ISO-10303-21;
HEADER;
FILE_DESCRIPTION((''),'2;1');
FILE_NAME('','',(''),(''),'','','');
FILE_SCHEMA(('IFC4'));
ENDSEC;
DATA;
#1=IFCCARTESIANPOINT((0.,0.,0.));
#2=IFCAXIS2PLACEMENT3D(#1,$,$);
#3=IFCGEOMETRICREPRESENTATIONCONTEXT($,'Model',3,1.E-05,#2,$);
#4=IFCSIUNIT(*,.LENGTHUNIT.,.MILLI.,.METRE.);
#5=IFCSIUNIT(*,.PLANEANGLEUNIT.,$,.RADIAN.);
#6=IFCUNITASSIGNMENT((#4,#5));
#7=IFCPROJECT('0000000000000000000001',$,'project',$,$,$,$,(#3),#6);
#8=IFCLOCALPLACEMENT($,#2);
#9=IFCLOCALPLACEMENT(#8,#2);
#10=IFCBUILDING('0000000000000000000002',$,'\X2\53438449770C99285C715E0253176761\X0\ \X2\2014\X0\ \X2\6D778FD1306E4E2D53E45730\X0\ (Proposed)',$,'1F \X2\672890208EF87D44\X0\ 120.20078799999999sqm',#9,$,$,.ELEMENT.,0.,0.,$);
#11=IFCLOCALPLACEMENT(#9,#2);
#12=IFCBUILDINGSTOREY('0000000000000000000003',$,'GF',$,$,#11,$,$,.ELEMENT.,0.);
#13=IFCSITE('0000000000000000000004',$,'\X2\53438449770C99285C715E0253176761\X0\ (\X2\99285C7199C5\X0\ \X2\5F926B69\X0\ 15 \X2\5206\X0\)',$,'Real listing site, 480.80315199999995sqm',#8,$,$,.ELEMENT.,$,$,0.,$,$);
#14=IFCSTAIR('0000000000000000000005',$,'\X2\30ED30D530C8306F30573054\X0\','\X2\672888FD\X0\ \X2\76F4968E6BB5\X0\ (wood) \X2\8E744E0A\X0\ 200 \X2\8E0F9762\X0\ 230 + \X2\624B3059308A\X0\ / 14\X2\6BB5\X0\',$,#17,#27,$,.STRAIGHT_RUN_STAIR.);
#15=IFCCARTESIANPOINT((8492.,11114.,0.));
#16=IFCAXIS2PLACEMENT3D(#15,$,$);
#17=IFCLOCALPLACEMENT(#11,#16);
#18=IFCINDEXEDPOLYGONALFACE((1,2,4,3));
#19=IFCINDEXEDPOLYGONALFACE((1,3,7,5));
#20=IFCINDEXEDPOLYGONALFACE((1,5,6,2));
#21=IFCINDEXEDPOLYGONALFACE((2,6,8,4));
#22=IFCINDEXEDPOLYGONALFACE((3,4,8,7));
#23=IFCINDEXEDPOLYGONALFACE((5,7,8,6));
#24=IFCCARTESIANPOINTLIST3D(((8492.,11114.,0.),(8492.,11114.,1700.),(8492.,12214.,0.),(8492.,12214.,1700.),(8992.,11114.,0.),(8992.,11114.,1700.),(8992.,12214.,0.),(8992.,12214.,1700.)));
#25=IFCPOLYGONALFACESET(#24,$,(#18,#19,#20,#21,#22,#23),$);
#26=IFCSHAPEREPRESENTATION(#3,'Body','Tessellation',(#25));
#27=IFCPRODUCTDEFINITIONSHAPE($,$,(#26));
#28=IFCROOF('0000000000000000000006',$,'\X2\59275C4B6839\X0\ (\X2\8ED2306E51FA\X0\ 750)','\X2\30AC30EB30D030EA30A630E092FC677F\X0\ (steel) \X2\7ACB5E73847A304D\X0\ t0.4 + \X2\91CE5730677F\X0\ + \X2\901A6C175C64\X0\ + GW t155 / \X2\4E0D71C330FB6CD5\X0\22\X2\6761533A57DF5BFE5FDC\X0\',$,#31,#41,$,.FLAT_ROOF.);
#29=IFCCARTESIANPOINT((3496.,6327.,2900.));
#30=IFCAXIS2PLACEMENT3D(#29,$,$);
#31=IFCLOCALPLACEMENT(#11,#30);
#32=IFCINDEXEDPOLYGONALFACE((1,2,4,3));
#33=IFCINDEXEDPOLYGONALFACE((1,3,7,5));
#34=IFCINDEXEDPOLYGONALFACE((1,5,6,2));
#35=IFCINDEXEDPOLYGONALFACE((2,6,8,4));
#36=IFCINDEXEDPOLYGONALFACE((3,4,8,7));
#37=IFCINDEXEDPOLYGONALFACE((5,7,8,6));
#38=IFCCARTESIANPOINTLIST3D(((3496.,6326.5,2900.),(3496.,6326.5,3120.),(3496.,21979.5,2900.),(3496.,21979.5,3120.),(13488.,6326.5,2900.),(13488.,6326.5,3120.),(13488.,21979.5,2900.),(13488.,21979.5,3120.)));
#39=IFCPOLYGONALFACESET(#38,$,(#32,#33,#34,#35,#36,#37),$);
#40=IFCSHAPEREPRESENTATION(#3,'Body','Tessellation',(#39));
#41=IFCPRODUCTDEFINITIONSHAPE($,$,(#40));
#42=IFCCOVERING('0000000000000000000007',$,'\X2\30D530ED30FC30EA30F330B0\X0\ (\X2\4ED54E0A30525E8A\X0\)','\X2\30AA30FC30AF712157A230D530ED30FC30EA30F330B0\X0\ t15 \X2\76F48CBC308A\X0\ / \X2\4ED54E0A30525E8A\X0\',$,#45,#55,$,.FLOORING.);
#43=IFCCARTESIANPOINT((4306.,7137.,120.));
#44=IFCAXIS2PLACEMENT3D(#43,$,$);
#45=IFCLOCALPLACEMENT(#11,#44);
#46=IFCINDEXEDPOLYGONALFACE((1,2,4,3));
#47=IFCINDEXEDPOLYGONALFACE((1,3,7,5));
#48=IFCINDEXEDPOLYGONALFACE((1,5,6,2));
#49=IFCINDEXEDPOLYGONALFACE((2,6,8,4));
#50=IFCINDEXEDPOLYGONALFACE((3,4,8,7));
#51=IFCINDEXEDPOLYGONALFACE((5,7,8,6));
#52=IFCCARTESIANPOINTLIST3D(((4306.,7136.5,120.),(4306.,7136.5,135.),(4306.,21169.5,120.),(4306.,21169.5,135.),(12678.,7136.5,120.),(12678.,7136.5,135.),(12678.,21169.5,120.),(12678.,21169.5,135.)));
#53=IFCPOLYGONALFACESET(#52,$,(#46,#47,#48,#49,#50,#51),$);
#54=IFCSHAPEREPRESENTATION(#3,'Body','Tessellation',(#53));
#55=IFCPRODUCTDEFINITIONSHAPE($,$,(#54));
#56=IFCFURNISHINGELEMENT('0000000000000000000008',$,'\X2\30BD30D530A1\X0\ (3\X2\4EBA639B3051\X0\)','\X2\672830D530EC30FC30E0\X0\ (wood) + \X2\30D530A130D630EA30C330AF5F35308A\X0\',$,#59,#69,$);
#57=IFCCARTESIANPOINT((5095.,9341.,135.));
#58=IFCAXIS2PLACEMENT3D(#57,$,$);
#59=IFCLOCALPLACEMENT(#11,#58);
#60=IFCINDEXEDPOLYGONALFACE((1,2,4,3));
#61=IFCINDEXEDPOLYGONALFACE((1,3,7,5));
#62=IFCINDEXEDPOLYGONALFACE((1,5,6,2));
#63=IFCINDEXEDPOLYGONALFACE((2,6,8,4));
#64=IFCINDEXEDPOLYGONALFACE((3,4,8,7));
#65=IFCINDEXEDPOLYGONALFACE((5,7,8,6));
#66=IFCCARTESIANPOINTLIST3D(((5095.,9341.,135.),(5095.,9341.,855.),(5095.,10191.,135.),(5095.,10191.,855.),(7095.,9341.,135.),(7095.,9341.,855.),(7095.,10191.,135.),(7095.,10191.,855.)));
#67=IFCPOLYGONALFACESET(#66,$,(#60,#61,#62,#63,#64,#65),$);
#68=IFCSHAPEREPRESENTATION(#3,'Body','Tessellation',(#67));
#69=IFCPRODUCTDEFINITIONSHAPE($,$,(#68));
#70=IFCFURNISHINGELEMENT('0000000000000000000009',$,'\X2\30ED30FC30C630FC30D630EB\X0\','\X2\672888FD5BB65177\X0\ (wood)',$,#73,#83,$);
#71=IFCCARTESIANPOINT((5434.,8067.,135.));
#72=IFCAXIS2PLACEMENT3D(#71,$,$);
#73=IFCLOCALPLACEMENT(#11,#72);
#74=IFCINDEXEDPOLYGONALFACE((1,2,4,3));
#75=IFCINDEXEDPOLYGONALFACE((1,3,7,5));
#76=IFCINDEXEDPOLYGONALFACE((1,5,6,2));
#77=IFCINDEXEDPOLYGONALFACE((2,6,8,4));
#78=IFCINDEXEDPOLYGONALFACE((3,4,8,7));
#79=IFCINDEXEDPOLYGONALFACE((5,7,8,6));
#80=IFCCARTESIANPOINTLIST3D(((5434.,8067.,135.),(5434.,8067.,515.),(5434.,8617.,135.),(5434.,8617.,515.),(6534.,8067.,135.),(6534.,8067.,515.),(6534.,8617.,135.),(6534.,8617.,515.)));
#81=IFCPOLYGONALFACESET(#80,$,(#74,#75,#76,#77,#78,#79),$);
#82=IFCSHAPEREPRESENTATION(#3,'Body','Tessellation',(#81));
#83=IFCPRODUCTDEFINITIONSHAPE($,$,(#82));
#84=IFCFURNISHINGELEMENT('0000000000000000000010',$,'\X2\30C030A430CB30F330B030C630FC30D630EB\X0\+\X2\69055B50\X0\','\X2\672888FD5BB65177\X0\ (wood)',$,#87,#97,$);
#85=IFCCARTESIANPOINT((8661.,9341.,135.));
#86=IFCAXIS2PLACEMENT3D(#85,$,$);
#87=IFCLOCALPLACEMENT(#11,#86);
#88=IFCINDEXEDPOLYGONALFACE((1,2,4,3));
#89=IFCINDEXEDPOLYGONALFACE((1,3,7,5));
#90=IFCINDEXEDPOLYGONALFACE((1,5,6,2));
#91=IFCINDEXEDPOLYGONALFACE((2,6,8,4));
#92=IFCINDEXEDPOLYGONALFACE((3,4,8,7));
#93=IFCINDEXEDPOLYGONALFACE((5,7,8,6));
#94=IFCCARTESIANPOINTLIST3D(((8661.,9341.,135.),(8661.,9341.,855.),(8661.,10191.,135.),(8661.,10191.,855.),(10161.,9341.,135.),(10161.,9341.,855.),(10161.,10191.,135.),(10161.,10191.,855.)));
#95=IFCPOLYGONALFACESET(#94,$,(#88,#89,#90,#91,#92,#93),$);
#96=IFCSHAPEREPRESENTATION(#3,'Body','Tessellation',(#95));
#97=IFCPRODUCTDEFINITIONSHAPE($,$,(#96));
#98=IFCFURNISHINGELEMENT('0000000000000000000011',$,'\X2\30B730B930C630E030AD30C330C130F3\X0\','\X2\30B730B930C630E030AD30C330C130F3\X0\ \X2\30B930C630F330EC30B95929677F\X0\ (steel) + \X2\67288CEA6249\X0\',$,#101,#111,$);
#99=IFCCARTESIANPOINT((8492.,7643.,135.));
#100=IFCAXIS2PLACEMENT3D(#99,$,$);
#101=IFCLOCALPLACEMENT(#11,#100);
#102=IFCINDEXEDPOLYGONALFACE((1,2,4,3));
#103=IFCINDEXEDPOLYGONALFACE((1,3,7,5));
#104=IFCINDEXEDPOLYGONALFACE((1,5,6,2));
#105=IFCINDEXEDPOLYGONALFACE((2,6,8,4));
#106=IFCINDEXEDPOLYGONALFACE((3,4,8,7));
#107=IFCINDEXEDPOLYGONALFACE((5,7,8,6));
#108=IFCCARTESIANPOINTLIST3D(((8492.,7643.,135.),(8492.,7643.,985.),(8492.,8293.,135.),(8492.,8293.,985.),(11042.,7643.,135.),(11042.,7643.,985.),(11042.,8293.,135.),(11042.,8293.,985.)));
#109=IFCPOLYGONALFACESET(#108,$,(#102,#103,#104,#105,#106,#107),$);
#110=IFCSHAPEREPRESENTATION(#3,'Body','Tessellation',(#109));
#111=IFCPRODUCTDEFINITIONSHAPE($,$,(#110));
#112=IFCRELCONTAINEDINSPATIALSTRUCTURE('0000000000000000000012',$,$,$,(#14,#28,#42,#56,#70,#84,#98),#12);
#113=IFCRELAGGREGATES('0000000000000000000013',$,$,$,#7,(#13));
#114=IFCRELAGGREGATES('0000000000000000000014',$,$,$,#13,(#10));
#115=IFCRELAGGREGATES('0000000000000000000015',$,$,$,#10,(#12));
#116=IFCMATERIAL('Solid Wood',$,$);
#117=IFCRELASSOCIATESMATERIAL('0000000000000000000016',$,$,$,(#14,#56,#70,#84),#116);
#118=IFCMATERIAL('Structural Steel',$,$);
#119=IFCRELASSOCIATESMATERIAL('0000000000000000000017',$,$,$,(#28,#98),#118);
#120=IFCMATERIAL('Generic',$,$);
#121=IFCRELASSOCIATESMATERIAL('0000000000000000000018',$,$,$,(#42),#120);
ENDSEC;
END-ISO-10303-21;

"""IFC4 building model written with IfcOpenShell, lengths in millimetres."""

from ifc_helpers import new_model, si_unit, frame, frame_2d, origin, place, context, project, spatial, rectangle, extrude, material, element, save


model = new_model("IFC4")

# Units and contexts
model_context = context("Model", 3, precision=1e-05, world=origin())
ifc_project = project(units=[si_unit("LENGTHUNIT", "METRE", prefix="MILLI"), si_unit("PLANEANGLEUNIT", "RADIAN")], contexts=[model_context])

# Site, building, storey
site_placement = place(None, origin())
site = spatial("IfcSite", under=ifc_project, at=site_placement, Name="千葉県館山市北条 (館山駅 徒歩 15 分)", ObjectType="Real listing site, 480.80315199999995sqm", CompositionType="ELEMENT", RefElevation=0.0)
building_placement = place(site_placement, origin())
building = spatial("IfcBuilding", under=site, at=building_placement, Name="千葉県館山市北条 — 海近の中古地 (Proposed)", ObjectType="1F 木造軸組 120.20078799999999sqm", CompositionType="ELEMENT", ElevationOfRefHeight=0.0, ElevationOfTerrain=0.0)
storey_placement = place(building_placement, origin())
storey = spatial("IfcBuildingStorey", under=building, at=storey_placement, Name="GF", CompositionType="ELEMENT", Elevation=0.0)

# Shared definitions
ifc_material_1 = material(Name="Solid Wood")

# Stair
stair_placement = place(storey_placement, frame((8492.0, 11114.0, 0.0)))
element("IfcStair", 1, at=stair_placement, inside=storey, material=ifc_material_1, Name="ロフトはしご", Description="木製 直階段 (wood) 蹴上 200 踏面 230 + 手すり / 14段", PredefinedType="STRAIGHT_RUN_STAIR", context=model_context, shape_type="SweptSolid", body=[
    extrude(rectangle(XDim=500.0, YDim=1100.0, at=frame_2d((250.0, 550.0))), frame((8492.0, 11114.0, 0.0)), (0.0, 0.0, 1.0), 1700.0),
])

# Roof
ifc_material_2 = material(Name="Structural Steel")
roof_placement = place(storey_placement, frame((3496.0, 6327.0, 2900.0)))
element("IfcRoof", 2, at=roof_placement, inside=storey, material=ifc_material_2, Name="大屋根 (軒の出 750)", Description="ガルバリウム鋼板 (steel) 立平葺き t0.4 + 野地板 + 通気層 + GW t155 / 不燃・法22条区域対応", PredefinedType="FLAT_ROOF", context=model_context, shape_type="SweptSolid", body=[
    extrude(rectangle(XDim=9992.0, YDim=15653.0, at=frame_2d((4996.0, 7826.0))), frame((3496.0, 6327.0, 2900.0)), (0.0, 0.0, 1.0), 220.0),
])

# Covering
ifc_material_3 = material(Name="Generic")
covering_placement = place(storey_placement, frame((4306.0, 7137.0, 120.0)))
element("IfcCovering", 3, at=covering_placement, inside=storey, material=ifc_material_3, Name="フローリング (仕上げ床)", Description="オーク無垢フローリング t15 直貼り / 仕上げ床", PredefinedType="FLOORING", context=model_context, shape_type="SweptSolid", body=[
    extrude(rectangle(XDim=8372.0, YDim=14033.0, at=frame_2d((4186.0, 7016.0))), frame((4306.0, 7137.0, 120.0)), (0.0, 0.0, 1.0), 15.0),
])

# Furnishing elements
furnishing_1_placement = place(storey_placement, frame((5095.0, 9341.0, 135.0)))
element("IfcFurnishingElement", 4, at=furnishing_1_placement, inside=storey, material=ifc_material_1, Name="ソファ (3人掛け)", Description="木フレーム (wood) + ファブリック張り", context=model_context, shape_type="SweptSolid", body=[
    extrude(rectangle(XDim=2000.0, YDim=850.0, at=frame_2d((1000.0, 425.0))), frame((5095.0, 9341.0, 135.0)), (0.0, 0.0, 1.0), 720.0),
])
furnishing_2_placement = place(storey_placement, frame((5434.0, 8067.0, 135.0)))
element("IfcFurnishingElement", 5, at=furnishing_2_placement, inside=storey, material=ifc_material_1, Name="ローテーブル", Description="木製家具 (wood)", context=model_context, shape_type="SweptSolid", body=[
    extrude(rectangle(XDim=1100.0, YDim=550.0, at=frame_2d((550.0, 275.0))), frame((5434.0, 8067.0, 135.0)), (0.0, 0.0, 1.0), 380.0),
])
furnishing_3_placement = place(storey_placement, frame((8661.0, 9341.0, 135.0)))
element("IfcFurnishingElement", 6, at=furnishing_3_placement, inside=storey, material=ifc_material_1, Name="ダイニングテーブル+椅子", Description="木製家具 (wood)", context=model_context, shape_type="SweptSolid", body=[
    extrude(rectangle(XDim=1500.0, YDim=850.0, at=frame_2d((750.0, 425.0))), frame((8661.0, 9341.0, 135.0)), (0.0, 0.0, 1.0), 720.0),
])
furnishing_4_placement = place(storey_placement, frame((8492.0, 7643.0, 135.0)))
element("IfcFurnishingElement", 7, at=furnishing_4_placement, inside=storey, material=ifc_material_2, Name="システムキッチン", Description="システムキッチン ステンレス天板 (steel) + 木質扉", context=model_context, shape_type="SweptSolid", body=[
    extrude(rectangle(XDim=2550.0, YDim=650.0, at=frame_2d((1275.0, 325.0))), frame((8492.0, 7643.0, 135.0)), (0.0, 0.0, 1.0), 850.0),
])

save(model, "model.ifc")
